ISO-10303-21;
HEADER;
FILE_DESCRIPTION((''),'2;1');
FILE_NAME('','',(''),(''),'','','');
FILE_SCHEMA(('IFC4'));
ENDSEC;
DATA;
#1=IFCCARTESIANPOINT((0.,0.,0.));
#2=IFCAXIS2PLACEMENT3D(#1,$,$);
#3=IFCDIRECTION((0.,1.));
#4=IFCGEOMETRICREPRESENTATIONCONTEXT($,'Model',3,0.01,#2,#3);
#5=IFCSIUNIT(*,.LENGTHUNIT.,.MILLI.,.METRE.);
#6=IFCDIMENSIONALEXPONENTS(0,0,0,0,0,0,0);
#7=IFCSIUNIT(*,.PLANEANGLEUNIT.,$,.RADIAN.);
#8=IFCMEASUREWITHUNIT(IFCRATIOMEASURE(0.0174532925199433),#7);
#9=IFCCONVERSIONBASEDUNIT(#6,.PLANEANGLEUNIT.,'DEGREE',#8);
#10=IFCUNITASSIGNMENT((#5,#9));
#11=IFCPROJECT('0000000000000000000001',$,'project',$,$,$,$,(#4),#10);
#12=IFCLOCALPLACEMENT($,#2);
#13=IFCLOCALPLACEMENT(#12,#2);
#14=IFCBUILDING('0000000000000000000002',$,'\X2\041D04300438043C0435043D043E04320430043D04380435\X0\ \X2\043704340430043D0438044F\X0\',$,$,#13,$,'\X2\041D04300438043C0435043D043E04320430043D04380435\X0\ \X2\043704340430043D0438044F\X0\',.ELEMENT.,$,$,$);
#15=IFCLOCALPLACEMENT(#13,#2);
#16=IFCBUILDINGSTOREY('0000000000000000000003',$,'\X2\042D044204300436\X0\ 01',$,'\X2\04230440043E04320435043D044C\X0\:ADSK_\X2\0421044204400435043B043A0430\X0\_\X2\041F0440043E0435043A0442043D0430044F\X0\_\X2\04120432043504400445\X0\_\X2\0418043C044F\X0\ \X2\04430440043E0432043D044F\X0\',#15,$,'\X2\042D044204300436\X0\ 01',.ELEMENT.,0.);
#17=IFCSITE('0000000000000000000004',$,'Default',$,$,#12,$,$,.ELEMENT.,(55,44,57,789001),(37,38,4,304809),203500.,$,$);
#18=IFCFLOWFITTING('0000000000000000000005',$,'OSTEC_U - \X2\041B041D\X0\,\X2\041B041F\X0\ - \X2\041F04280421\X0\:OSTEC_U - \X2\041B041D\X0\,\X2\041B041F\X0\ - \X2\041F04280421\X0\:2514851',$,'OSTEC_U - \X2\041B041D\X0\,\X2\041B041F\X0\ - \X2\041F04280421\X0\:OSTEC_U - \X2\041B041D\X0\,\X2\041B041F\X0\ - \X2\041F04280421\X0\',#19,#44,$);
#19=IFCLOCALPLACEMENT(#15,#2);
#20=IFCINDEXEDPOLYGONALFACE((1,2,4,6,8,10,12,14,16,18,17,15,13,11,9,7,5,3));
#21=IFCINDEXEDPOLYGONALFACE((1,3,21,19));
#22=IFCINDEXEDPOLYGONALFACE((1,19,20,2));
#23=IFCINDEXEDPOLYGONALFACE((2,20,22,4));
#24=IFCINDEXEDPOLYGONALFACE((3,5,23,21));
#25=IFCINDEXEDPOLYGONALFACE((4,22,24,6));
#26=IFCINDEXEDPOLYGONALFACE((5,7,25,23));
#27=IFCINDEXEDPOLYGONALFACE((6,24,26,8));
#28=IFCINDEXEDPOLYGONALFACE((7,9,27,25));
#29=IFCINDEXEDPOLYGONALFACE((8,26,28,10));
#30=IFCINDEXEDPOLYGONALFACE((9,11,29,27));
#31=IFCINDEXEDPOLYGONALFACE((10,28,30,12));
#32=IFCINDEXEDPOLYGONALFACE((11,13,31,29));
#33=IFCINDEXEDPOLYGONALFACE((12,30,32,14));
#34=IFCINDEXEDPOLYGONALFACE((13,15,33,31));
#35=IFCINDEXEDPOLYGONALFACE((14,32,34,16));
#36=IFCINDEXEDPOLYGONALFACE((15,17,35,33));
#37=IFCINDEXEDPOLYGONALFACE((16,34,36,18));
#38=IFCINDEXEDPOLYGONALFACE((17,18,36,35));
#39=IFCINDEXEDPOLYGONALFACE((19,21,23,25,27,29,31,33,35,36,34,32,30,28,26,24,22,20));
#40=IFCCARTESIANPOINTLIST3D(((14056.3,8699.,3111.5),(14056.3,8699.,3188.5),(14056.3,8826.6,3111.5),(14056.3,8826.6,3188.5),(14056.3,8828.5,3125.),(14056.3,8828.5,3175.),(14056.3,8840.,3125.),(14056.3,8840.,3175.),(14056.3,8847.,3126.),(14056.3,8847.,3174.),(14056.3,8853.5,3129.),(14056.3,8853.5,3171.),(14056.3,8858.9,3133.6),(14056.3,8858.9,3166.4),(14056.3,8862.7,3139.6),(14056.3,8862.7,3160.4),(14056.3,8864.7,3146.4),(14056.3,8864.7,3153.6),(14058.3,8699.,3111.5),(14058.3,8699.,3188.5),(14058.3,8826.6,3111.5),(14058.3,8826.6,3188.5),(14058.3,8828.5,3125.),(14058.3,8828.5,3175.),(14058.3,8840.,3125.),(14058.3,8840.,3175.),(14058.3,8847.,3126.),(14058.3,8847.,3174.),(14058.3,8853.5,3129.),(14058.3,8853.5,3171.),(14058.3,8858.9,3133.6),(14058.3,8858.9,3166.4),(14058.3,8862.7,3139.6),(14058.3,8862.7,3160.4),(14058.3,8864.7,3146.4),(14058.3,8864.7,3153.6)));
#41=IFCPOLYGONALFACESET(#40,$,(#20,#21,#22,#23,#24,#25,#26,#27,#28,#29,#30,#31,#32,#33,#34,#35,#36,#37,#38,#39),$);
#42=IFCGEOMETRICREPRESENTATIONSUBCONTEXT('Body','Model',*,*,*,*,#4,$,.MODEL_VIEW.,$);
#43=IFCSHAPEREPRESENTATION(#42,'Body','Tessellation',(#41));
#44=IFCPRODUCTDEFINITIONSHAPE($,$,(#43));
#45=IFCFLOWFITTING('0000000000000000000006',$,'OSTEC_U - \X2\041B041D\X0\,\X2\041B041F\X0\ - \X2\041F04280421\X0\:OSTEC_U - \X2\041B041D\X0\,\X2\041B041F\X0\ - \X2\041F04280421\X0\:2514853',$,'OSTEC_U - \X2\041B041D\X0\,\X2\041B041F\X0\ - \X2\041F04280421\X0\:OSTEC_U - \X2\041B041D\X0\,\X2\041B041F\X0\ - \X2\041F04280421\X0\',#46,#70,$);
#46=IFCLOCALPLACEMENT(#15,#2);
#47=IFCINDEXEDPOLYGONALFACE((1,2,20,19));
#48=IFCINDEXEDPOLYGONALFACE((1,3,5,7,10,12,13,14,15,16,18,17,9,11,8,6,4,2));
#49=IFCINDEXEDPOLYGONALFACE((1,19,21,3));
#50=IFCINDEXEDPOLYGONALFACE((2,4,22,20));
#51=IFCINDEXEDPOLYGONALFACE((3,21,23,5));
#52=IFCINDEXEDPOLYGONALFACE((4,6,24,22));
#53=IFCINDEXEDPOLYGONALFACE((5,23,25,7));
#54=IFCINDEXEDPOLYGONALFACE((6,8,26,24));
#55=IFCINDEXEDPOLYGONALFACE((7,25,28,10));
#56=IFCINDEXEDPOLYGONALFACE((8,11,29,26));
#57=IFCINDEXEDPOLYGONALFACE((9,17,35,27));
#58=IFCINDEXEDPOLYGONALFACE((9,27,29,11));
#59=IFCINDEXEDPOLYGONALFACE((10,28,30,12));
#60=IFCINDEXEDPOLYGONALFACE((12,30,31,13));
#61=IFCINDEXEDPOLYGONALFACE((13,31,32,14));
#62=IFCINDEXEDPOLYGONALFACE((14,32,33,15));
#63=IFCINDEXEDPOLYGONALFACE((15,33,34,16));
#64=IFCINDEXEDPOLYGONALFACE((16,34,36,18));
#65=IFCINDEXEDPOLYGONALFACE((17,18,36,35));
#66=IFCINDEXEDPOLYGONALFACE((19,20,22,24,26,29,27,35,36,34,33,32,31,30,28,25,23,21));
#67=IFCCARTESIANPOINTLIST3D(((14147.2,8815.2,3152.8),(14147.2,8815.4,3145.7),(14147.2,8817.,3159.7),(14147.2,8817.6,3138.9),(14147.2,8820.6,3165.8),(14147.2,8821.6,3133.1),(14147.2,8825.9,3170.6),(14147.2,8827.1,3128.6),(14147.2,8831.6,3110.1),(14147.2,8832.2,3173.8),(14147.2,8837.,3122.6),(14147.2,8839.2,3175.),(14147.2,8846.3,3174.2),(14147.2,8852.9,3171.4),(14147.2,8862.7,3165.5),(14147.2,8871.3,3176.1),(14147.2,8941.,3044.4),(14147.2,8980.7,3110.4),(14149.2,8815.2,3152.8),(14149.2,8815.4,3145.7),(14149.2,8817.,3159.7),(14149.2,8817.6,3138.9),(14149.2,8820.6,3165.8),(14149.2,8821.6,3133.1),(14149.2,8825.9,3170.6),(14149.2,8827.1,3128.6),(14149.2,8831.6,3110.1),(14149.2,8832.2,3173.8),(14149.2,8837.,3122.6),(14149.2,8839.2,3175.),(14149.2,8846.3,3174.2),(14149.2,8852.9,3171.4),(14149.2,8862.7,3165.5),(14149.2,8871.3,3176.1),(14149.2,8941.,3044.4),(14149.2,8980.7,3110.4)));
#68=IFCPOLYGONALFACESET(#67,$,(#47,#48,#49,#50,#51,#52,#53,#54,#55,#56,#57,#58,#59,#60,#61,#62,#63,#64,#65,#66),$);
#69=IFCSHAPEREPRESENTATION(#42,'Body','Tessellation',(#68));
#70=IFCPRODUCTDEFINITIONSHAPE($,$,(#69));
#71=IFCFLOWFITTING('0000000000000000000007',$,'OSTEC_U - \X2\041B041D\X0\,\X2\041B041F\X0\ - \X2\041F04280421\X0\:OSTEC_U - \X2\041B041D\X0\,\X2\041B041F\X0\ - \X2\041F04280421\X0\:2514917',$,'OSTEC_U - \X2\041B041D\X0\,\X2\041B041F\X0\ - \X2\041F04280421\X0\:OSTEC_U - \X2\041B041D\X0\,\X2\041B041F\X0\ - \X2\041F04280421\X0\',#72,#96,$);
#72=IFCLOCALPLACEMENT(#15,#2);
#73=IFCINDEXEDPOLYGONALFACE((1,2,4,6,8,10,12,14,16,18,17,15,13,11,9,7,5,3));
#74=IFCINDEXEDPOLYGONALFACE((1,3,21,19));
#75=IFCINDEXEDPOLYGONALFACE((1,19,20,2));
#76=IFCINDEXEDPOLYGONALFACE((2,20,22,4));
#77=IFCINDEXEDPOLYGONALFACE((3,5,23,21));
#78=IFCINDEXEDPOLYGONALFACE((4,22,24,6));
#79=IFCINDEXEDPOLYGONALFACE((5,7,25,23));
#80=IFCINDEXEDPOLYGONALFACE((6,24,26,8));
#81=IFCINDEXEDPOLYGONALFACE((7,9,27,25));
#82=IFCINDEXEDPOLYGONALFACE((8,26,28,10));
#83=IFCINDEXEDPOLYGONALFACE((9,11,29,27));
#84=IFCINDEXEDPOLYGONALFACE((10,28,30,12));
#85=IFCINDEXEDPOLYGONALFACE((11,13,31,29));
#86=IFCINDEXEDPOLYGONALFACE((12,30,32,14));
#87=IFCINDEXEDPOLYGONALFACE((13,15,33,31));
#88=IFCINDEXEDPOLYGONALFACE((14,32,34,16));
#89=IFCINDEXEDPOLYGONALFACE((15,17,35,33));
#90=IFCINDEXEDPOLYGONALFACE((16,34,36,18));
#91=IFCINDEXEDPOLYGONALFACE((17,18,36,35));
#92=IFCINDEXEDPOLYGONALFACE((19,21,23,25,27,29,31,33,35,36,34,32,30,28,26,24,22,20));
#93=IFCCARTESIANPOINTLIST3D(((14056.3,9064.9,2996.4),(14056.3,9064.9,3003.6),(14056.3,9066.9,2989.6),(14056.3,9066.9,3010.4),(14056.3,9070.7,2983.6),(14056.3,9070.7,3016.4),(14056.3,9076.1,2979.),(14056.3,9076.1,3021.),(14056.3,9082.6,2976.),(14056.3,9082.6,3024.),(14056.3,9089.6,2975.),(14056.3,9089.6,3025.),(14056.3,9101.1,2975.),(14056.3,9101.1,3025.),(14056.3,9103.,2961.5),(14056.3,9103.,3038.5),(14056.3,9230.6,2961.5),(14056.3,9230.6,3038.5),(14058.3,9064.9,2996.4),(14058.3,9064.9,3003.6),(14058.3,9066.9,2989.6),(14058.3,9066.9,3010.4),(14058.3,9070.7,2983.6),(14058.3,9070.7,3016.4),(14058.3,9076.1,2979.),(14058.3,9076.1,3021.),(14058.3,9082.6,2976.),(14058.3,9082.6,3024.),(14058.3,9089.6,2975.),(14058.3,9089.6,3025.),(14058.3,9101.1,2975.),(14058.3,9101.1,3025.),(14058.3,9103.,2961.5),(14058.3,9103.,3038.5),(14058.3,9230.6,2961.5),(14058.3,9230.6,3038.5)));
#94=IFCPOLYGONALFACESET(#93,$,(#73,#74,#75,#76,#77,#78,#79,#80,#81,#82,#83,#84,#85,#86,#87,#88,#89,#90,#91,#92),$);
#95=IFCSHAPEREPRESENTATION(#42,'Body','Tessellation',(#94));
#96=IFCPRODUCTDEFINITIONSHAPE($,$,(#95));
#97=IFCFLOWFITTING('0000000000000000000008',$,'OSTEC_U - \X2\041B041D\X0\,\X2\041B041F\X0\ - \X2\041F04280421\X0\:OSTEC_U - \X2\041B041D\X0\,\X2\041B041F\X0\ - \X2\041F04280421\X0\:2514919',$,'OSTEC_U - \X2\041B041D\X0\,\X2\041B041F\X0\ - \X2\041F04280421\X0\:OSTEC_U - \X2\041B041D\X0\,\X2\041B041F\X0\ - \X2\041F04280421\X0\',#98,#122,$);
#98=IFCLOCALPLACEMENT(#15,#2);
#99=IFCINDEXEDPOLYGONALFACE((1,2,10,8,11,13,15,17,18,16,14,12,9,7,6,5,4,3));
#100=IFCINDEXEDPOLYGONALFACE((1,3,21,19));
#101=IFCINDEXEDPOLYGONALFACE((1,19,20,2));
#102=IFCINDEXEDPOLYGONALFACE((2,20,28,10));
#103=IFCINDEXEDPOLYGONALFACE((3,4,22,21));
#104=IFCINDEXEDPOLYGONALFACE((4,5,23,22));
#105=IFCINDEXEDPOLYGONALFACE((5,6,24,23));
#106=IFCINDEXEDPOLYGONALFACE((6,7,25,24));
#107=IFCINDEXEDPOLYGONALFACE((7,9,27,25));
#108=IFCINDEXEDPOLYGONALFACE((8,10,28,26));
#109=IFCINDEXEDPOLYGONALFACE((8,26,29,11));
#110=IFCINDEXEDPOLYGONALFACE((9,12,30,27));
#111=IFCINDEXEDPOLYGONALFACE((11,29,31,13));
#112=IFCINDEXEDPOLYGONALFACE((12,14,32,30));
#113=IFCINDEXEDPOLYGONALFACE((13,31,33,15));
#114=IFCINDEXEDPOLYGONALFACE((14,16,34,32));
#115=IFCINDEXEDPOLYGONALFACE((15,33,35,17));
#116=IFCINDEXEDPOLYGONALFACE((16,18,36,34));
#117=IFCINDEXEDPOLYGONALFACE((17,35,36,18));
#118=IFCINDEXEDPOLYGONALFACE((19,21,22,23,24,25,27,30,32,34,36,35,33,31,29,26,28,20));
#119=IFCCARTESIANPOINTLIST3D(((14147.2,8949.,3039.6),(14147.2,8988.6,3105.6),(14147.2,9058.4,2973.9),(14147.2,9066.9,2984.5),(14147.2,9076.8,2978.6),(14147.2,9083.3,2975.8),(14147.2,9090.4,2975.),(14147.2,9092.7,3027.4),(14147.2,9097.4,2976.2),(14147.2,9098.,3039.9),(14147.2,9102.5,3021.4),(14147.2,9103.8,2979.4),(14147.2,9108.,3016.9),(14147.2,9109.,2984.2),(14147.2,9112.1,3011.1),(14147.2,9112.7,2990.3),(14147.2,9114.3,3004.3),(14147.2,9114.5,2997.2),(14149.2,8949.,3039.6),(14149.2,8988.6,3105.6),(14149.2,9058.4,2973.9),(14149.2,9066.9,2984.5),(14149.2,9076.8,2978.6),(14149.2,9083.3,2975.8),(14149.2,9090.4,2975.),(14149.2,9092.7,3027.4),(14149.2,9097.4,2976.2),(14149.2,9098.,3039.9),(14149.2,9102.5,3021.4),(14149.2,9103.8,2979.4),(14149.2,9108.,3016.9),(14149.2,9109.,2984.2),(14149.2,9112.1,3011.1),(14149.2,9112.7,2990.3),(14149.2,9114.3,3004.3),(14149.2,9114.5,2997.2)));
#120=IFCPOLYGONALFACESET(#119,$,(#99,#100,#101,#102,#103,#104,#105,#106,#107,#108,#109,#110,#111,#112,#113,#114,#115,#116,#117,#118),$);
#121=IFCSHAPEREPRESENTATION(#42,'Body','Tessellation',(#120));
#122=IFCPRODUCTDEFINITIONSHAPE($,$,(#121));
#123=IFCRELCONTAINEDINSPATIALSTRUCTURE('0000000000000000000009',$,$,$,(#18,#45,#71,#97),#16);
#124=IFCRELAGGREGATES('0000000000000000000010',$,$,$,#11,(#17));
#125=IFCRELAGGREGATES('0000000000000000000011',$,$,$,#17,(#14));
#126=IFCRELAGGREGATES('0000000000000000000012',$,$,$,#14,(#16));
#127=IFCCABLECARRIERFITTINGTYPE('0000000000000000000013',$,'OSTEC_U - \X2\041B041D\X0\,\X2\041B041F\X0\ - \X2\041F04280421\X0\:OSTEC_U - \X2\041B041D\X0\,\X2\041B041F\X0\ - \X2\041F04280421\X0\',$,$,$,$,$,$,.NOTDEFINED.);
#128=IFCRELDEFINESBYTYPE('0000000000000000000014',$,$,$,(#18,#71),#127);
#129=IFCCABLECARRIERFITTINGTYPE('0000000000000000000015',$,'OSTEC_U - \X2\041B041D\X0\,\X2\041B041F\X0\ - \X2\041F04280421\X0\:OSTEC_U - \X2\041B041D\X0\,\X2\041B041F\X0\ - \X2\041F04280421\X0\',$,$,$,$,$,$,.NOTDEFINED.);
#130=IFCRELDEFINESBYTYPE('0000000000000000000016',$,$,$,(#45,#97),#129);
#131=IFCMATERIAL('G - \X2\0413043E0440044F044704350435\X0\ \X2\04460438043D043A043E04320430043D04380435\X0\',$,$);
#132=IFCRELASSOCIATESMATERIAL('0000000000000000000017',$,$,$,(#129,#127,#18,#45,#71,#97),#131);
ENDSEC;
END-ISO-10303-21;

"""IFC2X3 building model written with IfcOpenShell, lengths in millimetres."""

from ifc_helpers import new_model, entity, si_unit, converted_unit, direction, frame, frame_2d, origin, place, context, subcontext, project, spatial, polyline, circle_curve, parameter, trimmed, segment, composite_curve, outline, extrude, source, transform, mapped, material, type_object, type_shapes, element, save


model = new_model("IFC2X3")

# Units and contexts
model_context = context("Model", 3, precision=0.01, world=origin(), true_north=direction((0.0, 1.0)))
body_context = subcontext(model_context, "Body", "Model", "MODEL_VIEW")
ifc_project = project(units=[si_unit("LENGTHUNIT", "METRE", prefix="MILLI"), converted_unit("PLANEANGLEUNIT", "DEGREE", entity("IfcRatioMeasure", 0.0174532925199433), si_unit("PLANEANGLEUNIT", "RADIAN"), dimensions=[0, 0, 0, 0, 0, 0, 0])], contexts=[model_context])

# Site, building, storey
site_placement = place(None, origin())
site = spatial("IfcSite", under=ifc_project, at=site_placement, Name="Default", CompositionType="ELEMENT", RefLatitude=(55, 44, 57, 789001), RefLongitude=(37, 38, 4, 304809), RefElevation=203500.0)
building_placement = place(site_placement, origin())
building = spatial("IfcBuilding", under=site, at=building_placement, Name="Наименование здания", LongName="Наименование здания", CompositionType="ELEMENT")
storey_placement = place(building_placement, origin())
storey = spatial("IfcBuildingStorey", under=building, at=storey_placement, Name="Этаж 01", ObjectType="Уровень:ADSK_Стрелка_Проектная_Вверх_Имя уровня", LongName="Этаж 01", CompositionType="ELEMENT", Elevation=0.0)

# Flow fittings
ifc_material_1 = material(Name="G - Горячее цинкование")
cable_carrier_fitting_type_1 = type_object("IfcCableCarrierFittingType", Name="OSTEC_U - ЛН,ЛП - ПШС:OSTEC_U - ЛН,ЛП - ПШС", PredefinedType="NOTDEFINED", material=ifc_material_1)
shared_shape_1 = source(origin(), body_context, "Body", "SweptSolid", [
    extrude(outline(composite_curve([segment(trimmed(circle_curve(frame_2d((-41.5, 0.0), x_axis=(1.0, 0.0)), 25.0), [parameter(90.0)], [parameter(270.0)], True, "PARAMETER"), True, "CONTINUOUS"), segment(polyline([(-41.5, -25.0), (-30.0, -25.0)]), True, "CONTINUOUS"), segment(polyline([(-30.0, -25.0), (-28.1, -38.5)]), True, "CONTINUOUS"), segment(polyline([(-28.1, -38.5), (99.5, -38.5)]), True, "CONTINUOUS"), segment(polyline([(99.5, -38.5), (99.5, 38.5)]), True, "CONTINUOUS"), segment(polyline([(99.5, 38.5), (-28.1, 38.5)]), True, "CONTINUOUS"), segment(polyline([(-28.1, 38.5), (-30.0, 25.0)]), True, "CONTINUOUS"), segment(polyline([(-30.0, 25.0), (-41.5, 25.0)]), True, "CONTINUOUS")], self_intersect=False)), frame((41.5, 0.0, 0.0)), (0.0, 0.0, 1.0), 2.0),
])
type_shapes(cable_carrier_fitting_type_1, [shared_shape_1])
cable_carrier_fitting_type_2 = type_object("IfcCableCarrierFittingType", Name="OSTEC_U - ЛН,ЛП - ПШС:OSTEC_U - ЛН,ЛП - ПШС", PredefinedType="NOTDEFINED", material=ifc_material_1)
type_shapes(cable_carrier_fitting_type_2, [shared_shape_1])
for number, where, z_axis, x_axis, name in (
    (1, (14058.3, 8840.0, 3150.0), (-1.0, 0.0, 0.0), (0.0, -1.0, 0.0), "OSTEC_U - ЛН,ЛП - ПШС:OSTEC_U - ЛН,ЛП - ПШС:2514851"),
):
    element("IfcFlowFitting", number, at=place(storey_placement, frame(where, z_axis=z_axis, x_axis=x_axis)), inside=storey, type_object=cable_carrier_fitting_type_2, material=ifc_material_1, Name=name, ObjectType="OSTEC_U - ЛН,ЛП - ПШС:OSTEC_U - ЛН,ЛП - ПШС", context=body_context, shape_type="MappedRepresentation", body=[
        mapped(shared_shape_1, transform((0.0, 0.0, 0.0), scale=1.0)),
    ])
flow_fitting_1_placement = place(storey_placement, frame((14147.2, 8840.0, 3150.0), z_axis=(1.0, 0.0, 0.0), x_axis=(0.0, 0.857167, -0.515038)))
element("IfcFlowFitting", 2, at=flow_fitting_1_placement, inside=storey, type_object=cable_carrier_fitting_type_1, material=ifc_material_1, Name="OSTEC_U - ЛН,ЛП - ПШС:OSTEC_U - ЛН,ЛП - ПШС:2514853", ObjectType="OSTEC_U - ЛН,ЛП - ПШС:OSTEC_U - ЛН,ЛП - ПШС", context=body_context, shape_type="MappedRepresentation", body=[
    mapped(shared_shape_1, transform((0.0, 0.0, 0.0), scale=1.0)),
])
flow_fitting_2_placement = place(storey_placement, frame((14058.3, 9089.6, 3000.0), z_axis=(-1.0, 0.0, 0.0), x_axis=(0.0, 1.0, 0.0)))
element("IfcFlowFitting", 3, at=flow_fitting_2_placement, inside=storey, type_object=cable_carrier_fitting_type_2, material=ifc_material_1, Name="OSTEC_U - ЛН,ЛП - ПШС:OSTEC_U - ЛН,ЛП - ПШС:2514917", ObjectType="OSTEC_U - ЛН,ЛП - ПШС:OSTEC_U - ЛН,ЛП - ПШС", context=body_context, shape_type="MappedRepresentation", body=[
    mapped(shared_shape_1, transform((0.0, 0.0, 0.0), scale=1.0)),
])
flow_fitting_3_placement = place(storey_placement, frame((14147.2, 9089.6, 3000.0), z_axis=(1.0, 0.0, 0.0), x_axis=(0.0, -0.857167, 0.515038)))
element("IfcFlowFitting", 4, at=flow_fitting_3_placement, inside=storey, type_object=cable_carrier_fitting_type_1, material=ifc_material_1, Name="OSTEC_U - ЛН,ЛП - ПШС:OSTEC_U - ЛН,ЛП - ПШС:2514919", ObjectType="OSTEC_U - ЛН,ЛП - ПШС:OSTEC_U - ЛН,ЛП - ПШС", context=body_context, shape_type="MappedRepresentation", body=[
    mapped(shared_shape_1, transform((0.0, 0.0, 0.0), scale=1.0)),
])

save(model, "model.ifc")
